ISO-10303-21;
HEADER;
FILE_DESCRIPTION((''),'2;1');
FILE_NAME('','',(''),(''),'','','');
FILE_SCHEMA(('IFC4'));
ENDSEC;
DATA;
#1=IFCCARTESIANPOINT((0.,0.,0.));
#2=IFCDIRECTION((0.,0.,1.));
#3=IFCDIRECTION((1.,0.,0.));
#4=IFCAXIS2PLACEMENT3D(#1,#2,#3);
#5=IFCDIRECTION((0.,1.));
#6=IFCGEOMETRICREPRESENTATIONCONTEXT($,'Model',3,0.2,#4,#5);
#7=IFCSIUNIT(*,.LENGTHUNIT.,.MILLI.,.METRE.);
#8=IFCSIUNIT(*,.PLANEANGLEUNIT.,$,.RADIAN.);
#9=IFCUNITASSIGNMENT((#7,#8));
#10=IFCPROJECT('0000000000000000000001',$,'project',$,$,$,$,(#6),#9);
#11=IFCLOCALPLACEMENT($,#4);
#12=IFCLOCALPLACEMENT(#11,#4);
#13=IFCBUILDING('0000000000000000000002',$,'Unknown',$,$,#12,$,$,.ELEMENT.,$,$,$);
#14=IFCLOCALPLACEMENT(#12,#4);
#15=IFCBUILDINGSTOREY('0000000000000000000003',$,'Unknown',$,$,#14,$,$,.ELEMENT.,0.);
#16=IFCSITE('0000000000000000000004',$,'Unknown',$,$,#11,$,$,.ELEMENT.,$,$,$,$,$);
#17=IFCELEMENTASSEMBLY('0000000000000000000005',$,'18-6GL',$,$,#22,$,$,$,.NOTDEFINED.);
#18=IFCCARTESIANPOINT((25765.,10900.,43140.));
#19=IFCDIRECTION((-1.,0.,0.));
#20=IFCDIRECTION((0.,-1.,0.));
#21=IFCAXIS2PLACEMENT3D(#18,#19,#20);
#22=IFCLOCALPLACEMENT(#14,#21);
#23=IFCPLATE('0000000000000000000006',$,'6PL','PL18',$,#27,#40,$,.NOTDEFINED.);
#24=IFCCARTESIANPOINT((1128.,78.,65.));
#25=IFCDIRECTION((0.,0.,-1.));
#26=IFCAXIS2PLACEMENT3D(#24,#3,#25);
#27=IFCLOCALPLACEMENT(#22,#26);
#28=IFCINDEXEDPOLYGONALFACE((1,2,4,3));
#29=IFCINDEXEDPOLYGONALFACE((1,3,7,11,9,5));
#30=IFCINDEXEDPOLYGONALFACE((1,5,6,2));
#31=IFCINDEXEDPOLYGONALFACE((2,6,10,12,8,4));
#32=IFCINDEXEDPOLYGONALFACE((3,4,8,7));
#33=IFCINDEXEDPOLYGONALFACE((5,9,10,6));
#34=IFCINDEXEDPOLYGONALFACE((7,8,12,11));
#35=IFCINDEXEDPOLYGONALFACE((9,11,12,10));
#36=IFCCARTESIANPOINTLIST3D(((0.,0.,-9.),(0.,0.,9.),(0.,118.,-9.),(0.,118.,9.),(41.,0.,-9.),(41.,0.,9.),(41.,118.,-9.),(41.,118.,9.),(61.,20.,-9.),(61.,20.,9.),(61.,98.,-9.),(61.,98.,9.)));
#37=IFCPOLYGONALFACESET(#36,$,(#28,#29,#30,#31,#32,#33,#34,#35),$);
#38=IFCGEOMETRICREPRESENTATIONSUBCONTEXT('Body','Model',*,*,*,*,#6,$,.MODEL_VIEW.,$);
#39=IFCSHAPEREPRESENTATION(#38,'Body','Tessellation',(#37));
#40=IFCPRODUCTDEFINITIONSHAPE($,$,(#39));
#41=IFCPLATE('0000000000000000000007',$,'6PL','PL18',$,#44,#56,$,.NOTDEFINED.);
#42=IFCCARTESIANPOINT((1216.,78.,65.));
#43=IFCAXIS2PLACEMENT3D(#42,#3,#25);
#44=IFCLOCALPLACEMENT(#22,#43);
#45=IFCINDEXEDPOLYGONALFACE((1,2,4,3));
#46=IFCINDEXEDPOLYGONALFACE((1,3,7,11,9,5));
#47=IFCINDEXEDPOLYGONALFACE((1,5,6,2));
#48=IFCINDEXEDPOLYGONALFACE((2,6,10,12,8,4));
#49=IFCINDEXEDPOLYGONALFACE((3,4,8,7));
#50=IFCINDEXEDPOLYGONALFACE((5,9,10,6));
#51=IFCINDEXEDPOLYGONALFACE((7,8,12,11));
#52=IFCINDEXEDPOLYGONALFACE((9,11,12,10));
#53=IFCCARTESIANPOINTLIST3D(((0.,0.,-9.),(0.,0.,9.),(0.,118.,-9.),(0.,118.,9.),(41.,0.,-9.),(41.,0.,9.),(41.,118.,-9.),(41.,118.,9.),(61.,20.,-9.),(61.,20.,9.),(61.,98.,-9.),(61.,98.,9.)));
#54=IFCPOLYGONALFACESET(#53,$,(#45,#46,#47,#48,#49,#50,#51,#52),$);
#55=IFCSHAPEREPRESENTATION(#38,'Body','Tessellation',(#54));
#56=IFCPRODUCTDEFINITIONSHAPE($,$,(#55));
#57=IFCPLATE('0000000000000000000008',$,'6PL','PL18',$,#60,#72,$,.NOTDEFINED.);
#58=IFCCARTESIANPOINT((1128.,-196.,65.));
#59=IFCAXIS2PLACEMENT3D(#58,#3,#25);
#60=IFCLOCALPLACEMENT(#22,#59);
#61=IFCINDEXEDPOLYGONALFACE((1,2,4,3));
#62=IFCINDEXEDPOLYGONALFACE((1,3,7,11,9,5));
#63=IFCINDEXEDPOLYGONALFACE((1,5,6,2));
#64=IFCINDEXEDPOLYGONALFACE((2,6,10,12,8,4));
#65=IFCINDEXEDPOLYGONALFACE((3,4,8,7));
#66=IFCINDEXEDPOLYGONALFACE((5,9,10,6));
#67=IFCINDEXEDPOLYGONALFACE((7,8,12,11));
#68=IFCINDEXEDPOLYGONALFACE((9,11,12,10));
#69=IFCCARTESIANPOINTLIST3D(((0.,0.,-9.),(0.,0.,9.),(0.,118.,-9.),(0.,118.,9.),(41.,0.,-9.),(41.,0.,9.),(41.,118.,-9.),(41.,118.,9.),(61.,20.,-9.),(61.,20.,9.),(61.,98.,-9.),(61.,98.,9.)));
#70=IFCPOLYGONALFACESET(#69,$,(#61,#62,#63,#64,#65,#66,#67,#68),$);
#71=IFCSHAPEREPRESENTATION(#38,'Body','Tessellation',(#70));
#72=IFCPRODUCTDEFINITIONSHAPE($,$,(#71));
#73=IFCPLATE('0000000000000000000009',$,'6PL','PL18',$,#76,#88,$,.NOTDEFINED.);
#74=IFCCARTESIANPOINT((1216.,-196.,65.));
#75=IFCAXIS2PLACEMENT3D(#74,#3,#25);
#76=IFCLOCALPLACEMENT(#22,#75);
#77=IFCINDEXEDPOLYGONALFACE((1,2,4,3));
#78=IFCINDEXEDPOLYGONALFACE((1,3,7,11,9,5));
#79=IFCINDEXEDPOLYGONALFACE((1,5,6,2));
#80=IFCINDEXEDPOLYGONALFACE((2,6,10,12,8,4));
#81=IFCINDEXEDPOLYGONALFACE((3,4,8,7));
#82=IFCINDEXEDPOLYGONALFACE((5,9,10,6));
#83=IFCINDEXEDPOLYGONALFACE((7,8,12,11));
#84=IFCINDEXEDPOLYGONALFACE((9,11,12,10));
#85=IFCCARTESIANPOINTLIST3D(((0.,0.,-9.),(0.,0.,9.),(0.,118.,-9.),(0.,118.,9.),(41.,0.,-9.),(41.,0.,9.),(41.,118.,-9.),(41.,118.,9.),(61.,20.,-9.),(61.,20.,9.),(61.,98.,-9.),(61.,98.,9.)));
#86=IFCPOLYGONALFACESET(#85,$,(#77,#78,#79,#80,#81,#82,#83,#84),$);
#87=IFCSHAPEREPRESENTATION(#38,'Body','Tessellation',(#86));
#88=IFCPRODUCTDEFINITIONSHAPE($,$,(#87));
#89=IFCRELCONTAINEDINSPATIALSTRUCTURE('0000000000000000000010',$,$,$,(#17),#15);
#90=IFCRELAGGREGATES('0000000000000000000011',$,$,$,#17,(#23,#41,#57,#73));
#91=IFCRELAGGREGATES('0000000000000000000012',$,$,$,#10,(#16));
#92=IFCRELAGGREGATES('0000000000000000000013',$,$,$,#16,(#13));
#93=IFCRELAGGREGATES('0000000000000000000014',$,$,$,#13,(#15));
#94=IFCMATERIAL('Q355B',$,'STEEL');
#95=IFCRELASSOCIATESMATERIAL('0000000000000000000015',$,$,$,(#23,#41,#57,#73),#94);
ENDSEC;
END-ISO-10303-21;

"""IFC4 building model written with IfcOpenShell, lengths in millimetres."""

from ifc_helpers import new_model, si_unit, direction, frame, origin_with_axes, place, context, subcontext, project, spatial, line, indexed_curve, outline, extrude, material, element, aggregate, save


model = new_model("IFC4")

# Units and contexts
model_context = context("Model", 3, precision=0.2, world=origin_with_axes(), true_north=direction((0.0, 1.0)))
body_context = subcontext(model_context, "Body", "Model", "MODEL_VIEW")
ifc_project = project(units=[si_unit("LENGTHUNIT", "METRE", prefix="MILLI"), si_unit("PLANEANGLEUNIT", "RADIAN")], contexts=[model_context])

# Site, building, storey
site_placement = place(None, origin_with_axes())
site = spatial("IfcSite", under=ifc_project, at=site_placement, Name="Unknown", CompositionType="ELEMENT")
building_placement = place(site_placement, origin_with_axes())
building = spatial("IfcBuilding", under=site, at=building_placement, Name="Unknown", CompositionType="ELEMENT")
storey_placement = place(building_placement, origin_with_axes())
storey = spatial("IfcBuildingStorey", under=building, at=storey_placement, Name="Unknown", CompositionType="ELEMENT", Elevation=0.0)

# Element assembly
assembly_1_placement = place(storey_placement, frame((25765.0, 10900.0, 43140.0), z_axis=(-1.0, 0.0, 0.0), x_axis=(0.0, -1.0, 0.0)))
assembly_1 = element("IfcElementAssembly", 1, at=assembly_1_placement, inside=storey, Name="18-6GL", PredefinedType="NOTDEFINED")
ifc_material_1 = material(Name="Q355B", Category="STEEL")

# Plates
plate_1_placement = place(assembly_1_placement, frame((1128.0, 78.0, 65.0), z_axis=(1.0, 0.0, 0.0), x_axis=(0.0, 0.0, -1.0)))
plate_1 = element("IfcPlate", 2, at=plate_1_placement, material=ifc_material_1, Name="6PL", Description="PL18", PredefinedType="NOTDEFINED", context=body_context, shape_type="SolidModel", body=[
    extrude(outline(indexed_curve([(0.0, 0.0), (41.0, 0.0), (61.0, 20.0), (61.0, 98.0), (41.0, 118.0), (0.0, 118.0)], segments=[line(1, 2, 3, 4, 5, 6, 1)])), frame((0.0, 0.0, 9.0), z_axis=(0.0, 0.0, 1.0), x_axis=(1.0, 0.0, 0.0)), (0.0, 0.0, -1.0), 18.0),
])
plate_2_placement = place(assembly_1_placement, frame((1216.0, 78.0, 65.0), z_axis=(1.0, 0.0, 0.0), x_axis=(0.0, 0.0, -1.0)))
plate_2 = element("IfcPlate", 3, at=plate_2_placement, material=ifc_material_1, Name="6PL", Description="PL18", PredefinedType="NOTDEFINED", context=body_context, shape_type="SolidModel", body=[
    extrude(outline(indexed_curve([(0.0, 0.0), (41.0, 0.0), (61.0, 20.0), (61.0, 98.0), (41.0, 118.0), (0.0, 118.0)], segments=[line(1, 2, 3, 4, 5, 6, 1)])), frame((0.0, 0.0, 9.0), z_axis=(0.0, 0.0, 1.0), x_axis=(1.0, 0.0, 0.0)), (0.0, 0.0, -1.0), 18.0),
])
plate_3_placement = place(assembly_1_placement, frame((1128.0, -196.0, 65.0), z_axis=(1.0, 0.0, 0.0), x_axis=(0.0, 0.0, -1.0)))
plate_3 = element("IfcPlate", 4, at=plate_3_placement, material=ifc_material_1, Name="6PL", Description="PL18", PredefinedType="NOTDEFINED", context=body_context, shape_type="SolidModel", body=[
    extrude(outline(indexed_curve([(0.0, 0.0), (41.0, 0.0), (61.0, 20.0), (61.0, 98.0), (41.0, 118.0), (0.0, 118.0)], segments=[line(1, 2, 3, 4, 5, 6, 1)])), frame((0.0, 0.0, 9.0), z_axis=(0.0, 0.0, 1.0), x_axis=(1.0, 0.0, 0.0)), (0.0, 0.0, -1.0), 18.0),
])
plate_4_placement = place(assembly_1_placement, frame((1216.0, -196.0, 65.0), z_axis=(1.0, 0.0, 0.0), x_axis=(0.0, 0.0, -1.0)))
plate_4 = element("IfcPlate", 5, at=plate_4_placement, material=ifc_material_1, Name="6PL", Description="PL18", PredefinedType="NOTDEFINED", context=body_context, shape_type="SolidModel", body=[
    extrude(outline(indexed_curve([(0.0, 0.0), (41.0, 0.0), (61.0, 20.0), (61.0, 98.0), (41.0, 118.0), (0.0, 118.0)], segments=[line(1, 2, 3, 4, 5, 6, 1)])), frame((0.0, 0.0, 9.0), z_axis=(0.0, 0.0, 1.0), x_axis=(1.0, 0.0, 0.0)), (0.0, 0.0, -1.0), 18.0),
])

aggregate(assembly_1, [plate_1, plate_2, plate_3, plate_4])

save(model, "model.ifc")
